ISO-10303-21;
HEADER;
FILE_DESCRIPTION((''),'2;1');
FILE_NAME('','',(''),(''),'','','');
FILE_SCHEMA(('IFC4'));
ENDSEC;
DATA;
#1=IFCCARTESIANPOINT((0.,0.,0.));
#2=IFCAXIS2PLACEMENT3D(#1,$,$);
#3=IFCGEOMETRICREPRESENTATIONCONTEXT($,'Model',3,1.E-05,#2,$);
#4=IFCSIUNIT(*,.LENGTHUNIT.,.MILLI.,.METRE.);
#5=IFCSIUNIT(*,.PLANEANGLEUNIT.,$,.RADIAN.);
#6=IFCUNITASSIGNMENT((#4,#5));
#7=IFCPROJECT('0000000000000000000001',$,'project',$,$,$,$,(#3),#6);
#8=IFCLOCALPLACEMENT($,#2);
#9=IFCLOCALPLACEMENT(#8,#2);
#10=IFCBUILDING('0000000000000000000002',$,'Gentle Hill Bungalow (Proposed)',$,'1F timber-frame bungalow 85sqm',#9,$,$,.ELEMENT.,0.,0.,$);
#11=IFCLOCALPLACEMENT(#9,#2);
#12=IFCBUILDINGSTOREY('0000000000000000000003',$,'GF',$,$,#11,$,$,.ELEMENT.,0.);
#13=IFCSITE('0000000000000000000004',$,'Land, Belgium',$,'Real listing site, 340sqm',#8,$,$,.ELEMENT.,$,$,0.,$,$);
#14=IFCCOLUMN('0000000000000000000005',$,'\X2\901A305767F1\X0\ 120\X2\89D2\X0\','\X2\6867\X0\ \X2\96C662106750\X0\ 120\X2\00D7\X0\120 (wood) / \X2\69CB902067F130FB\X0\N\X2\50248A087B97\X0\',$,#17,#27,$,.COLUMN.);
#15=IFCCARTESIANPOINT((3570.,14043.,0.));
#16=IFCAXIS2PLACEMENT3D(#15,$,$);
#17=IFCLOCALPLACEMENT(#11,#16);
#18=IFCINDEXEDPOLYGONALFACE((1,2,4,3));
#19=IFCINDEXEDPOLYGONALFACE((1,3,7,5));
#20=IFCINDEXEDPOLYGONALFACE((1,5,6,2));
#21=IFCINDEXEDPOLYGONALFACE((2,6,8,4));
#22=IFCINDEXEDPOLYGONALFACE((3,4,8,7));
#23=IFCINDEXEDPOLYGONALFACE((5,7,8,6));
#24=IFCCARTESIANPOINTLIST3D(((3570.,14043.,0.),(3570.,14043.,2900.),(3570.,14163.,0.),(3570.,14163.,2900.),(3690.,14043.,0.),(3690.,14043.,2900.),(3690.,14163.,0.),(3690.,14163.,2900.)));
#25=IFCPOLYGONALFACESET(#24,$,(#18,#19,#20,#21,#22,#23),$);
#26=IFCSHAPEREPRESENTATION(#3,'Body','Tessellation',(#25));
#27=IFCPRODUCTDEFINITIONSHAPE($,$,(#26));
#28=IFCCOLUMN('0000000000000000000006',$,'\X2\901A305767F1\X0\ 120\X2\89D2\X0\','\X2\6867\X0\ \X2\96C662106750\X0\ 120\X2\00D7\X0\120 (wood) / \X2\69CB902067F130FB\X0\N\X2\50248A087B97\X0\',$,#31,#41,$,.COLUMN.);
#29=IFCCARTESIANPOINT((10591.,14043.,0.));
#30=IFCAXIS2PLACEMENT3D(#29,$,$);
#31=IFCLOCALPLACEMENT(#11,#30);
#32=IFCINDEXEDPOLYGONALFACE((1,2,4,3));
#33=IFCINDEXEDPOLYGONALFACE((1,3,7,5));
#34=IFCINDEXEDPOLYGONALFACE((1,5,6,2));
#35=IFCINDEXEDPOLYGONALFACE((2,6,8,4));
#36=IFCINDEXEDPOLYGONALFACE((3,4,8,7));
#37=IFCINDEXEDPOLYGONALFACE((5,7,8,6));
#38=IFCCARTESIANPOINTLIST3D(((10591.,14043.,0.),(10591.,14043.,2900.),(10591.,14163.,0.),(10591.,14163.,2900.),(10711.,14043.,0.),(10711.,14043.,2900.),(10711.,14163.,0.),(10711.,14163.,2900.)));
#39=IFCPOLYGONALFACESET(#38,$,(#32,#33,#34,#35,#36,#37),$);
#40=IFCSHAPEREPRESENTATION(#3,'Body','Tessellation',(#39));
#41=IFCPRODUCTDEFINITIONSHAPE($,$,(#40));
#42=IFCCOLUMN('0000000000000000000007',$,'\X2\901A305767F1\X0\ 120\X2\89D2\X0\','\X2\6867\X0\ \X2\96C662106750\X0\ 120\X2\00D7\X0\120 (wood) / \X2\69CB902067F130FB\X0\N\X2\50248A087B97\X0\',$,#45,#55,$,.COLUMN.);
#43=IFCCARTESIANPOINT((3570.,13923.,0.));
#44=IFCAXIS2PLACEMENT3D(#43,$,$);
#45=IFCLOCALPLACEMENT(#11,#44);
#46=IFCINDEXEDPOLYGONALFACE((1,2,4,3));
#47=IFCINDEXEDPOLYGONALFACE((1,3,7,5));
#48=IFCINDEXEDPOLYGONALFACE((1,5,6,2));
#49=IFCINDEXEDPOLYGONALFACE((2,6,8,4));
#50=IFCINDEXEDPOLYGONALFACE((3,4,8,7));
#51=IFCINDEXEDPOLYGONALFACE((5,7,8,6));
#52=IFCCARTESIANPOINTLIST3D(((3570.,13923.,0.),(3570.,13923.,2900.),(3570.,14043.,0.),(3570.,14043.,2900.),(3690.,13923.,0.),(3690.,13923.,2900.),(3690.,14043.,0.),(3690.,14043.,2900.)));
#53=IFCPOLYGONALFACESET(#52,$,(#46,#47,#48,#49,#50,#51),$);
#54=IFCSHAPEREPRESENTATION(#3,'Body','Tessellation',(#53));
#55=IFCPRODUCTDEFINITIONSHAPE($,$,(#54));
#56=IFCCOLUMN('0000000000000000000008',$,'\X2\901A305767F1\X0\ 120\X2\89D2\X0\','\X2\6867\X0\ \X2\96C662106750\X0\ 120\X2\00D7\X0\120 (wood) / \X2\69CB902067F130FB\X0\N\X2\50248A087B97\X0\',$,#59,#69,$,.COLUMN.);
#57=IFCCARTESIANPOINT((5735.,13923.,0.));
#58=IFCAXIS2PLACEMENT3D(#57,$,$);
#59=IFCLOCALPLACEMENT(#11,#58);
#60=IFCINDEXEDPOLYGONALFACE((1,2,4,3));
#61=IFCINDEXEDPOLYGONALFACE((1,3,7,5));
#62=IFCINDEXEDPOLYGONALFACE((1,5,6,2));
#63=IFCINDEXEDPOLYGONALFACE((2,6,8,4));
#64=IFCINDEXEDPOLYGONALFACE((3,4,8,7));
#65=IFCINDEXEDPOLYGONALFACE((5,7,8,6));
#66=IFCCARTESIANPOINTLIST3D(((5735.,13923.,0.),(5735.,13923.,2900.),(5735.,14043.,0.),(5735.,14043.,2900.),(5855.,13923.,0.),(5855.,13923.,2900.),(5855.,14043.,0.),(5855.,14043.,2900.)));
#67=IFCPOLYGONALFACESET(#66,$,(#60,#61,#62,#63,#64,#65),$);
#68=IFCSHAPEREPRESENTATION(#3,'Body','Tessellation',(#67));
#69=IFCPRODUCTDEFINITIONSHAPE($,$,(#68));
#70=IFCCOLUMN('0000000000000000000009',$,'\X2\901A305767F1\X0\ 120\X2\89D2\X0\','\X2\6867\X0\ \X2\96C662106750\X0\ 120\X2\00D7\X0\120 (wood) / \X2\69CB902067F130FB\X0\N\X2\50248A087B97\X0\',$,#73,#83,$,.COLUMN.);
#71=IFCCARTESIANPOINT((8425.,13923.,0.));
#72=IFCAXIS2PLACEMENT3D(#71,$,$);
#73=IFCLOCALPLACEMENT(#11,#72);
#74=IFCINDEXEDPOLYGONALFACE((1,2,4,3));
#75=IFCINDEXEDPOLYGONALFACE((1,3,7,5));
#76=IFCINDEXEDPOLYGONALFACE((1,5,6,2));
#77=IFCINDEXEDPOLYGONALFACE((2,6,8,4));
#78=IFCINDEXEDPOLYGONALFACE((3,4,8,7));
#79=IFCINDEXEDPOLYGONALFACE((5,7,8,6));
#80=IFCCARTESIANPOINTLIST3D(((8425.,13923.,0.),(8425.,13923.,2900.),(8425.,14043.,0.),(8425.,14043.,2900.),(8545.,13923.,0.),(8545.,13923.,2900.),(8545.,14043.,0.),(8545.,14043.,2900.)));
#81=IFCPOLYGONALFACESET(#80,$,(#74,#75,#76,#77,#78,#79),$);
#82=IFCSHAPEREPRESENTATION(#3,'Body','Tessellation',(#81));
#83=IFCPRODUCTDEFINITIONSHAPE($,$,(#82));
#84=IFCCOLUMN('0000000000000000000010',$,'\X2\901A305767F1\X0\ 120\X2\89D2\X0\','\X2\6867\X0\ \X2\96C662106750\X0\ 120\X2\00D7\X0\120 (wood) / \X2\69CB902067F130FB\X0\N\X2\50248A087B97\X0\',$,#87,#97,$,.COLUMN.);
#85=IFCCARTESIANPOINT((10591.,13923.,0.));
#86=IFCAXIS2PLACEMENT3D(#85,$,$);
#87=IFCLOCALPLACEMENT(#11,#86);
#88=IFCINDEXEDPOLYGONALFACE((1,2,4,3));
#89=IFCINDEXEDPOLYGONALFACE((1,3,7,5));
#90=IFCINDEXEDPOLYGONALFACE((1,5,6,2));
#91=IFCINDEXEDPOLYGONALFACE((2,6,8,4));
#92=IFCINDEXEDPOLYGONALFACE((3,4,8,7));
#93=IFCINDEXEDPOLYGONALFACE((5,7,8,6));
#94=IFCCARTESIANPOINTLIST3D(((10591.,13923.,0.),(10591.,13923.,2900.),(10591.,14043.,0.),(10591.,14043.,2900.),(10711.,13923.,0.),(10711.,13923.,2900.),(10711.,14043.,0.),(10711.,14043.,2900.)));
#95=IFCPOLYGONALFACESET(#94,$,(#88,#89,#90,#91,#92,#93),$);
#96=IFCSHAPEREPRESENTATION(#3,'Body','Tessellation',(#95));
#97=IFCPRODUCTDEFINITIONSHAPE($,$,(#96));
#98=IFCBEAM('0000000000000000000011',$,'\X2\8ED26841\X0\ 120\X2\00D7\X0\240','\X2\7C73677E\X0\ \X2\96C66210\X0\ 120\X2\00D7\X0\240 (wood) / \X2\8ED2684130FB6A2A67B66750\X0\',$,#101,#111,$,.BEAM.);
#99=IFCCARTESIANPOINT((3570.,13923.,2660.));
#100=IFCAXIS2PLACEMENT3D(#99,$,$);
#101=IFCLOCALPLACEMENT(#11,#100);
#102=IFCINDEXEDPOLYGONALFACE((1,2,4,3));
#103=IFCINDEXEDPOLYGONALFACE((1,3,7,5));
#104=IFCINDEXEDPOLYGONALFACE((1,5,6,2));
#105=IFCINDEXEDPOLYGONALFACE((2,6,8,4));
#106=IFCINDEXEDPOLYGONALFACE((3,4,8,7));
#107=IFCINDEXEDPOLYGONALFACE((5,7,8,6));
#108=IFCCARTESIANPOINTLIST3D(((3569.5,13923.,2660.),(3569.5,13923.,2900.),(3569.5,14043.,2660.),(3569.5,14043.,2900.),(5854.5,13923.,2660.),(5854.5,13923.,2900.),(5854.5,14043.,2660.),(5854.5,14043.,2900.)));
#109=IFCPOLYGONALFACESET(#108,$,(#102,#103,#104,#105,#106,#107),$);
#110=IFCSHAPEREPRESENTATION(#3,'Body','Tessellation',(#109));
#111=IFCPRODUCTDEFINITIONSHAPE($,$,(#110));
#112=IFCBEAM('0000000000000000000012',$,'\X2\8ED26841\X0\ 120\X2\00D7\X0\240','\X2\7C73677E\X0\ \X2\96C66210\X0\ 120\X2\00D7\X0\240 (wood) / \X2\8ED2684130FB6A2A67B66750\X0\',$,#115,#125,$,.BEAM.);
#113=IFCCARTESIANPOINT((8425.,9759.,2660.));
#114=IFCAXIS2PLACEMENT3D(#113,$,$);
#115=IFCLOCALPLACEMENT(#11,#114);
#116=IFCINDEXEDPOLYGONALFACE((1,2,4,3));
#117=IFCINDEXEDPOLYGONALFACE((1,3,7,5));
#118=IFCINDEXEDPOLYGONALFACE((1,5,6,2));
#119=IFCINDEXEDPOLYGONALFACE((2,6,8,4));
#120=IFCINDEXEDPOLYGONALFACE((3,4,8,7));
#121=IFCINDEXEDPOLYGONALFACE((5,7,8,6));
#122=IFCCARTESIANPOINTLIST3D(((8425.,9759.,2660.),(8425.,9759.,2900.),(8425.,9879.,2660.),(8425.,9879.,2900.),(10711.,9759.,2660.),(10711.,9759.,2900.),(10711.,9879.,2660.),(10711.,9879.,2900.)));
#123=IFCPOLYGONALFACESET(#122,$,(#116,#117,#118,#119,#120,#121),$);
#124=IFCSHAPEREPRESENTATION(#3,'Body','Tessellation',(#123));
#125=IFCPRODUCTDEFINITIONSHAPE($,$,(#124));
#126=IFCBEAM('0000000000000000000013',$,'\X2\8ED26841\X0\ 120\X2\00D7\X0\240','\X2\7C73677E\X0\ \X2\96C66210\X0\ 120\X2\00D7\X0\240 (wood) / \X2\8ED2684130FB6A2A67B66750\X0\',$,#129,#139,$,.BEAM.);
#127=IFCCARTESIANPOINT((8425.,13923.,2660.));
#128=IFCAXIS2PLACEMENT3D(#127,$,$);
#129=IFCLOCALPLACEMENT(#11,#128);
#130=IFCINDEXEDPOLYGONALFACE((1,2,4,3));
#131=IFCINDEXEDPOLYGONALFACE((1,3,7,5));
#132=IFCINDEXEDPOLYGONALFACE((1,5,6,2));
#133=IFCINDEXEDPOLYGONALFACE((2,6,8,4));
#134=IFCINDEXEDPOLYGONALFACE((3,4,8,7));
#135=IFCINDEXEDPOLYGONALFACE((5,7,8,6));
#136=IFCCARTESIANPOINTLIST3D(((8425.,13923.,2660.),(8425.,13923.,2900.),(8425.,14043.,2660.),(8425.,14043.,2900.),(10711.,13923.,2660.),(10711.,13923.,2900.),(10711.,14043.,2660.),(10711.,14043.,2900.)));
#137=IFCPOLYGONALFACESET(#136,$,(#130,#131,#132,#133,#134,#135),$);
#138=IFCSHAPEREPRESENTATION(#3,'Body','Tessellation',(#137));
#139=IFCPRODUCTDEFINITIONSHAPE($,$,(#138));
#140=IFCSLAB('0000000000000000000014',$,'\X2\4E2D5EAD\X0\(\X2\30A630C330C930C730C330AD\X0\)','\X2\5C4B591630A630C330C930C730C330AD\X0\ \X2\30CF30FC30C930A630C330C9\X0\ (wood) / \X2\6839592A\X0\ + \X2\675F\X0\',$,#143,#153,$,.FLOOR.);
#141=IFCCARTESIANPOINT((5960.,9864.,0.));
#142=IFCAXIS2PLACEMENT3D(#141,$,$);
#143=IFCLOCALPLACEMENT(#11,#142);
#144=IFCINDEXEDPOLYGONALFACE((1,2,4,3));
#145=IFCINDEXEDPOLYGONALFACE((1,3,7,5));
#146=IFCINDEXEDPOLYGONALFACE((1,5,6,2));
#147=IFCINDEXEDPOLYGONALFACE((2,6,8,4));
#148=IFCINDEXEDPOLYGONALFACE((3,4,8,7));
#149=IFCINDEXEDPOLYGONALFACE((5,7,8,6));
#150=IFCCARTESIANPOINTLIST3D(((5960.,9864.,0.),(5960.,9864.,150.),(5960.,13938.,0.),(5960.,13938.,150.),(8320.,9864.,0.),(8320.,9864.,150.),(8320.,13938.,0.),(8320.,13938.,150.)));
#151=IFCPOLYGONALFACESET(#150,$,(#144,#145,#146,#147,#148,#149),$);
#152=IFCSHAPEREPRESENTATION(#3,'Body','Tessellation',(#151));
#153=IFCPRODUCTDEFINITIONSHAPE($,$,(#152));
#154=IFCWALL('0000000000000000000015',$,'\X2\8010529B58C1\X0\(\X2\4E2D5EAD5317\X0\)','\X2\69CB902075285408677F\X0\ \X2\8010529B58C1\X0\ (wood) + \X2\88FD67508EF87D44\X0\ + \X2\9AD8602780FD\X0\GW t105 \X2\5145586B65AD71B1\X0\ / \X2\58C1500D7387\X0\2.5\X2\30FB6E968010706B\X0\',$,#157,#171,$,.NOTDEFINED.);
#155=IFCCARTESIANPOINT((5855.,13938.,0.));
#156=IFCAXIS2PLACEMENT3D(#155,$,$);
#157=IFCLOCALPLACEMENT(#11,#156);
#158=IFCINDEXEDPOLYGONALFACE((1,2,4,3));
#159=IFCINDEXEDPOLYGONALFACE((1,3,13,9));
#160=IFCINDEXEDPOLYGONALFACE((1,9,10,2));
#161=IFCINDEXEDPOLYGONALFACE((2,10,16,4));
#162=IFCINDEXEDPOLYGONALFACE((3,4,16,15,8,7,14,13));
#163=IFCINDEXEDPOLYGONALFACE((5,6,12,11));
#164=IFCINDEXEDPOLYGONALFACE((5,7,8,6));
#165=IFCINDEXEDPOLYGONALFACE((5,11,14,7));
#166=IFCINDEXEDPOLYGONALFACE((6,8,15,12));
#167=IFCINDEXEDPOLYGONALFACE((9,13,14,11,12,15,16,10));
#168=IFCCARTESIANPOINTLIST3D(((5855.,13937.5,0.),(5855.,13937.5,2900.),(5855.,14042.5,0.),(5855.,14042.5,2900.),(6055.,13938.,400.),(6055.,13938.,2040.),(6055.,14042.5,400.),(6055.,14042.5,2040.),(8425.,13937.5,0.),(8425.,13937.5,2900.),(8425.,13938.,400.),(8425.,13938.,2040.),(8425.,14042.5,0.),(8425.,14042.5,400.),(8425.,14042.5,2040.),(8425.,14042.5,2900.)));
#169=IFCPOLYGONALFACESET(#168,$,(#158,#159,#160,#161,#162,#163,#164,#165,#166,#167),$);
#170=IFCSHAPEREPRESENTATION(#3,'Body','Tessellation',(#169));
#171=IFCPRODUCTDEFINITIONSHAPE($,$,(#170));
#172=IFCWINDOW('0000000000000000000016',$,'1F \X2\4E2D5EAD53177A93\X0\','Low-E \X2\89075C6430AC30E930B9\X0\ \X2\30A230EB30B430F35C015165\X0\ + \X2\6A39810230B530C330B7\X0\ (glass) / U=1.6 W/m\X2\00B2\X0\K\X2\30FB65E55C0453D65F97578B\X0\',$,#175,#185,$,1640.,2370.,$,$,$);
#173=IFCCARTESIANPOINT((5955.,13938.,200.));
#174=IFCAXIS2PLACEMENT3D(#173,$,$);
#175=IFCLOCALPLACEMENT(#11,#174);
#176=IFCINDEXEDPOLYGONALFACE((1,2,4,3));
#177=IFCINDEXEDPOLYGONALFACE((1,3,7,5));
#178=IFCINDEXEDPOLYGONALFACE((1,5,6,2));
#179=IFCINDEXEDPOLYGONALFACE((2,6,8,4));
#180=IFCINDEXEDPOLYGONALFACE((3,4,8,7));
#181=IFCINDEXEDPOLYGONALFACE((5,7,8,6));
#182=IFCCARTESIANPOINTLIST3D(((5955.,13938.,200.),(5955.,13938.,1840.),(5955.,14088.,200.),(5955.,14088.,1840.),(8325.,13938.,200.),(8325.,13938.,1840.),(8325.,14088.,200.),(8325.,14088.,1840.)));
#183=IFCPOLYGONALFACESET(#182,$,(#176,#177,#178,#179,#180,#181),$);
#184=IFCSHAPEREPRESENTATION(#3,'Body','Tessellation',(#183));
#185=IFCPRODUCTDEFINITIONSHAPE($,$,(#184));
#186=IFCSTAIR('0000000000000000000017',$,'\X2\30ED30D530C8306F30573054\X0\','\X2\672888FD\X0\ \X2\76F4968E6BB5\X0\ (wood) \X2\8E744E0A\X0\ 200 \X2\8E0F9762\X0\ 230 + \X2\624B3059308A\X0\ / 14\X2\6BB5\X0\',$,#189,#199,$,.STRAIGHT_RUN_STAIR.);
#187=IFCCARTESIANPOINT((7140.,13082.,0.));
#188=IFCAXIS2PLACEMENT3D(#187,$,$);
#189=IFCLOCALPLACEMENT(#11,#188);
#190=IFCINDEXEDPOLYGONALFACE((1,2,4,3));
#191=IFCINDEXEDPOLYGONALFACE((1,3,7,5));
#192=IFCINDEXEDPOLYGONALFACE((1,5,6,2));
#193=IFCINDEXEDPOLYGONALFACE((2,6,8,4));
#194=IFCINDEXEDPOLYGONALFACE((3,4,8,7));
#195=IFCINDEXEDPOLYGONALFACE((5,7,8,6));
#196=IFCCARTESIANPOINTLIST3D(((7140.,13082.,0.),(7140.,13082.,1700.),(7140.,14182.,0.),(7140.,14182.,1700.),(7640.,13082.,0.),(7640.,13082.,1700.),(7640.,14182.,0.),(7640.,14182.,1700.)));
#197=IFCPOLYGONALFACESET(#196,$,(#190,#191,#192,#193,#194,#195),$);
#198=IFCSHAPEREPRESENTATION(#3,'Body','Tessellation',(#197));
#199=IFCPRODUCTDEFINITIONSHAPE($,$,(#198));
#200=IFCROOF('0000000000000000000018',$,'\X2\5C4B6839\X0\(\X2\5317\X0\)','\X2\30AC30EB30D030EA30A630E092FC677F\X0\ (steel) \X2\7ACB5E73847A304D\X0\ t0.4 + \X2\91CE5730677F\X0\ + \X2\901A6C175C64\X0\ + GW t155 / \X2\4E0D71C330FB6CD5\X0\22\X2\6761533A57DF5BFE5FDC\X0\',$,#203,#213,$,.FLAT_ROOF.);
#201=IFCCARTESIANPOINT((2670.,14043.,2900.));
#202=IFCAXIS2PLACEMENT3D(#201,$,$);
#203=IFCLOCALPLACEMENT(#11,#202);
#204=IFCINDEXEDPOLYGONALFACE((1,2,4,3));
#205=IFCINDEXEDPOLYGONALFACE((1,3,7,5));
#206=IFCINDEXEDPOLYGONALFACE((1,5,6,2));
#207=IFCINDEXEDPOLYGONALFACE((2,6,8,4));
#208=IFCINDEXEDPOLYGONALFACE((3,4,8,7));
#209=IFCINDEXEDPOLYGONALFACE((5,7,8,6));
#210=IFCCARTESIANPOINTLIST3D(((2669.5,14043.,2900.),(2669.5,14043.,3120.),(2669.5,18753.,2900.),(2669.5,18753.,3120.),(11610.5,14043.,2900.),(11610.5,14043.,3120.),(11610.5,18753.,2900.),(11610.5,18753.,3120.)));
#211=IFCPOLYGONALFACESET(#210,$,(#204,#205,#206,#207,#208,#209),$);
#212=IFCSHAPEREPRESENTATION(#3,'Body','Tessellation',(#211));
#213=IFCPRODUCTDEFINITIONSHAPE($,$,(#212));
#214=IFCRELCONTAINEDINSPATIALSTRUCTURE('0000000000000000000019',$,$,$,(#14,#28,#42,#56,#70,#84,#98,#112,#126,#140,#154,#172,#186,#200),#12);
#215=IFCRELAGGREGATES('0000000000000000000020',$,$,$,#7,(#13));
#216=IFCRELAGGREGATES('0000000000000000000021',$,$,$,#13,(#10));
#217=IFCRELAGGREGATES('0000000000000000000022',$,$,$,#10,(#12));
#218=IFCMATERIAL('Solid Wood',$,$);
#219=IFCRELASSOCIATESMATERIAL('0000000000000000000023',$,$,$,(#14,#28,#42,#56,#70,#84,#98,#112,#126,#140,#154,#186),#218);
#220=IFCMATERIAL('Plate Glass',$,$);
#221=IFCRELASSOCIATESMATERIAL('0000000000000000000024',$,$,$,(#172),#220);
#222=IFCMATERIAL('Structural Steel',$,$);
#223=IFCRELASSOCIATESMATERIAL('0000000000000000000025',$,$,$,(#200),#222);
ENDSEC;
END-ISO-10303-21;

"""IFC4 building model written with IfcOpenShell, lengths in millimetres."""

from ifc_helpers import new_model, si_unit, frame, frame_2d, origin, place, context, project, spatial, rectangle, extrude, material, element, fill, save


model = new_model("IFC4")

# Units and contexts
model_context = context("Model", 3, precision=1e-05, world=origin())
ifc_project = project(units=[si_unit("LENGTHUNIT", "METRE", prefix="MILLI"), si_unit("PLANEANGLEUNIT", "RADIAN")], contexts=[model_context])

# Site, building, storey
site_placement = place(None, origin())
site = spatial("IfcSite", under=ifc_project, at=site_placement, Name="Land, Belgium", ObjectType="Real listing site, 340sqm", CompositionType="ELEMENT", RefElevation=0.0)
building_placement = place(site_placement, origin())
building = spatial("IfcBuilding", under=site, at=building_placement, Name="Gentle Hill Bungalow (Proposed)", ObjectType="1F timber-frame bungalow 85sqm", CompositionType="ELEMENT", ElevationOfRefHeight=0.0, ElevationOfTerrain=0.0)
storey_placement = place(building_placement, origin())
storey = spatial("IfcBuildingStorey", under=building, at=storey_placement, Name="GF", CompositionType="ELEMENT", Elevation=0.0)

# Columns
ifc_material_1 = material(Name="Solid Wood")
column_1_placement = place(storey_placement, frame((3570.0, 14043.0, 0.0)))
element("IfcColumn", 1, at=column_1_placement, inside=storey, material=ifc_material_1, Name="通し柱 120角", Description="桧 集成材 120×120 (wood) / 構造柱・N値計算", PredefinedType="COLUMN", context=model_context, shape_type="SweptSolid", body=[
    extrude(rectangle(XDim=120.0, YDim=120.0, at=frame_2d((60.0, 60.0))), frame((3570.0, 14043.0, 0.0)), (0.0, 0.0, 1.0), 2900.0),
])
column_2_placement = place(storey_placement, frame((10591.0, 14043.0, 0.0)))
element("IfcColumn", 2, at=column_2_placement, inside=storey, material=ifc_material_1, Name="通し柱 120角", Description="桧 集成材 120×120 (wood) / 構造柱・N値計算", PredefinedType="COLUMN", context=model_context, shape_type="SweptSolid", body=[
    extrude(rectangle(XDim=120.0, YDim=120.0, at=frame_2d((60.0, 60.0))), frame((10591.0, 14043.0, 0.0)), (0.0, 0.0, 1.0), 2900.0),
])
column_3_placement = place(storey_placement, frame((3570.0, 13923.0, 0.0)))
element("IfcColumn", 3, at=column_3_placement, inside=storey, material=ifc_material_1, Name="通し柱 120角", Description="桧 集成材 120×120 (wood) / 構造柱・N値計算", PredefinedType="COLUMN", context=model_context, shape_type="SweptSolid", body=[
    extrude(rectangle(XDim=120.0, YDim=120.0, at=frame_2d((60.0, 60.0))), frame((3570.0, 13923.0, 0.0)), (0.0, 0.0, 1.0), 2900.0),
])
column_4_placement = place(storey_placement, frame((5735.0, 13923.0, 0.0)))
element("IfcColumn", 4, at=column_4_placement, inside=storey, material=ifc_material_1, Name="通し柱 120角", Description="桧 集成材 120×120 (wood) / 構造柱・N値計算", PredefinedType="COLUMN", context=model_context, shape_type="SweptSolid", body=[
    extrude(rectangle(XDim=120.0, YDim=120.0, at=frame_2d((60.0, 60.0))), frame((5735.0, 13923.0, 0.0)), (0.0, 0.0, 1.0), 2900.0),
])
column_5_placement = place(storey_placement, frame((8425.0, 13923.0, 0.0)))
element("IfcColumn", 5, at=column_5_placement, inside=storey, material=ifc_material_1, Name="通し柱 120角", Description="桧 集成材 120×120 (wood) / 構造柱・N値計算", PredefinedType="COLUMN", context=model_context, shape_type="SweptSolid", body=[
    extrude(rectangle(XDim=120.0, YDim=120.0, at=frame_2d((60.0, 60.0))), frame((8425.0, 13923.0, 0.0)), (0.0, 0.0, 1.0), 2900.0),
])
column_6_placement = place(storey_placement, frame((10591.0, 13923.0, 0.0)))
element("IfcColumn", 6, at=column_6_placement, inside=storey, material=ifc_material_1, Name="通し柱 120角", Description="桧 集成材 120×120 (wood) / 構造柱・N値計算", PredefinedType="COLUMN", context=model_context, shape_type="SweptSolid", body=[
    extrude(rectangle(XDim=120.0, YDim=120.0, at=frame_2d((60.0, 60.0))), frame((10591.0, 13923.0, 0.0)), (0.0, 0.0, 1.0), 2900.0),
])

# Beams
beam_1_placement = place(storey_placement, frame((3570.0, 13923.0, 2660.0)))
element("IfcBeam", 7, at=beam_1_placement, inside=storey, material=ifc_material_1, Name="軒桁 120×240", Description="米松 集成 120×240 (wood) / 軒桁・横架材", PredefinedType="BEAM", context=model_context, shape_type="SweptSolid", body=[
    extrude(rectangle(XDim=2285.0, YDim=120.0, at=frame_2d((1142.0, 60.0))), frame((3570.0, 13923.0, 2660.0)), (0.0, 0.0, 1.0), 240.0),
])
beam_2_placement = place(storey_placement, frame((8425.0, 9759.0, 2660.0)))
element("IfcBeam", 8, at=beam_2_placement, inside=storey, material=ifc_material_1, Name="軒桁 120×240", Description="米松 集成 120×240 (wood) / 軒桁・横架材", PredefinedType="BEAM", context=model_context, shape_type="SweptSolid", body=[
    extrude(rectangle(XDim=2286.0, YDim=120.0, at=frame_2d((1143.0, 60.0))), frame((8425.0, 9759.0, 2660.0)), (0.0, 0.0, 1.0), 240.0),
])
beam_3_placement = place(storey_placement, frame((8425.0, 13923.0, 2660.0)))
element("IfcBeam", 9, at=beam_3_placement, inside=storey, material=ifc_material_1, Name="軒桁 120×240", Description="米松 集成 120×240 (wood) / 軒桁・横架材", PredefinedType="BEAM", context=model_context, shape_type="SweptSolid", body=[
    extrude(rectangle(XDim=2286.0, YDim=120.0, at=frame_2d((1143.0, 60.0))), frame((8425.0, 13923.0, 2660.0)), (0.0, 0.0, 1.0), 240.0),
])

# Slab
slab_1_placement = place(storey_placement, frame((5960.0, 9864.0, 0.0)))
element("IfcSlab", 10, at=slab_1_placement, inside=storey, material=ifc_material_1, Name="中庭(ウッドデッキ)", Description="屋外ウッドデッキ ハードウッド (wood) / 根太 + 束", PredefinedType="FLOOR", context=model_context, shape_type="SweptSolid", body=[
    extrude(rectangle(XDim=2360.0, YDim=4074.0, at=frame_2d((1180.0, 2037.0))), frame((5960.0, 9864.0, 0.0)), (0.0, 0.0, 1.0), 150.0),
])

# Wall, opening, window
wall_placement = place(storey_placement, frame((5855.0, 13938.0, 0.0)))
wall = element("IfcWall", 11, at=wall_placement, inside=storey, material=ifc_material_1, Name="耐力壁(中庭北)", Description="構造用合板 耐力壁 (wood) + 製材軸組 + 高性能GW t105 充填断熱 / 壁倍率2.5・準耐火", PredefinedType="NOTDEFINED", context=model_context, shape_type="SweptSolid", body=[
    extrude(rectangle(XDim=2570.0, YDim=105.0, at=frame_2d((1285.0, 52.0))), frame((5855.0, 13938.0, 0.0)), (0.0, 0.0, 1.0), 2900.0),
])
opening_placement = place(storey_placement, frame((5955.0, 13938.0, 200.0)))
opening = element("IfcOpeningElement", 12, at=opening_placement, cuts=wall, PredefinedType="NOTDEFINED", context=model_context, shape_type="SweptSolid", body=[
    extrude(rectangle(XDim=2370.0, YDim=150.0, at=frame_2d((1185.0, 75.0))), frame((5955.0, 13938.0, 200.0)), (0.0, 0.0, 1.0), 1640.0),
])
ifc_material_2 = material(Name="Plate Glass")
window_placement = place(storey_placement, frame((5955.0, 13938.0, 200.0)))
window = element("IfcWindow", 13, at=window_placement, inside=storey, material=ifc_material_2, Name="1F 中庭北窓", Description="Low-E 複層ガラス アルゴン封入 + 樹脂サッシ (glass) / U=1.6 W/m²K・日射取得型", OverallHeight=1640.0, OverallWidth=2370.0, context=model_context, shape_type="SweptSolid", body=[
    extrude(rectangle(XDim=2370.0, YDim=150.0, at=frame_2d((1185.0, 75.0))), frame((5955.0, 13938.0, 200.0)), (0.0, 0.0, 1.0), 1640.0),
])
fill(opening, window)

# Stair
stair_placement = place(storey_placement, frame((7140.0, 13082.0, 0.0)))
element("IfcStair", 14, at=stair_placement, inside=storey, material=ifc_material_1, Name="ロフトはしご", Description="木製 直階段 (wood) 蹴上 200 踏面 230 + 手すり / 14段", PredefinedType="STRAIGHT_RUN_STAIR", context=model_context, shape_type="SweptSolid", body=[
    extrude(rectangle(XDim=500.0, YDim=1100.0, at=frame_2d((250.0, 550.0))), frame((7140.0, 13082.0, 0.0)), (0.0, 0.0, 1.0), 1700.0),
])

# Roof
ifc_material_3 = material(Name="Structural Steel")
roof_placement = place(storey_placement, frame((2670.0, 14043.0, 2900.0)))
element("IfcRoof", 15, at=roof_placement, inside=storey, material=ifc_material_3, Name="屋根(北)", Description="ガルバリウム鋼板 (steel) 立平葺き t0.4 + 野地板 + 通気層 + GW t155 / 不燃・法22条区域対応", PredefinedType="FLAT_ROOF", context=model_context, shape_type="SweptSolid", body=[
    extrude(rectangle(XDim=8941.0, YDim=4710.0, at=frame_2d((4470.0, 2355.0))), frame((2670.0, 14043.0, 2900.0)), (0.0, 0.0, 1.0), 220.0),
])

save(model, "model.ifc")
